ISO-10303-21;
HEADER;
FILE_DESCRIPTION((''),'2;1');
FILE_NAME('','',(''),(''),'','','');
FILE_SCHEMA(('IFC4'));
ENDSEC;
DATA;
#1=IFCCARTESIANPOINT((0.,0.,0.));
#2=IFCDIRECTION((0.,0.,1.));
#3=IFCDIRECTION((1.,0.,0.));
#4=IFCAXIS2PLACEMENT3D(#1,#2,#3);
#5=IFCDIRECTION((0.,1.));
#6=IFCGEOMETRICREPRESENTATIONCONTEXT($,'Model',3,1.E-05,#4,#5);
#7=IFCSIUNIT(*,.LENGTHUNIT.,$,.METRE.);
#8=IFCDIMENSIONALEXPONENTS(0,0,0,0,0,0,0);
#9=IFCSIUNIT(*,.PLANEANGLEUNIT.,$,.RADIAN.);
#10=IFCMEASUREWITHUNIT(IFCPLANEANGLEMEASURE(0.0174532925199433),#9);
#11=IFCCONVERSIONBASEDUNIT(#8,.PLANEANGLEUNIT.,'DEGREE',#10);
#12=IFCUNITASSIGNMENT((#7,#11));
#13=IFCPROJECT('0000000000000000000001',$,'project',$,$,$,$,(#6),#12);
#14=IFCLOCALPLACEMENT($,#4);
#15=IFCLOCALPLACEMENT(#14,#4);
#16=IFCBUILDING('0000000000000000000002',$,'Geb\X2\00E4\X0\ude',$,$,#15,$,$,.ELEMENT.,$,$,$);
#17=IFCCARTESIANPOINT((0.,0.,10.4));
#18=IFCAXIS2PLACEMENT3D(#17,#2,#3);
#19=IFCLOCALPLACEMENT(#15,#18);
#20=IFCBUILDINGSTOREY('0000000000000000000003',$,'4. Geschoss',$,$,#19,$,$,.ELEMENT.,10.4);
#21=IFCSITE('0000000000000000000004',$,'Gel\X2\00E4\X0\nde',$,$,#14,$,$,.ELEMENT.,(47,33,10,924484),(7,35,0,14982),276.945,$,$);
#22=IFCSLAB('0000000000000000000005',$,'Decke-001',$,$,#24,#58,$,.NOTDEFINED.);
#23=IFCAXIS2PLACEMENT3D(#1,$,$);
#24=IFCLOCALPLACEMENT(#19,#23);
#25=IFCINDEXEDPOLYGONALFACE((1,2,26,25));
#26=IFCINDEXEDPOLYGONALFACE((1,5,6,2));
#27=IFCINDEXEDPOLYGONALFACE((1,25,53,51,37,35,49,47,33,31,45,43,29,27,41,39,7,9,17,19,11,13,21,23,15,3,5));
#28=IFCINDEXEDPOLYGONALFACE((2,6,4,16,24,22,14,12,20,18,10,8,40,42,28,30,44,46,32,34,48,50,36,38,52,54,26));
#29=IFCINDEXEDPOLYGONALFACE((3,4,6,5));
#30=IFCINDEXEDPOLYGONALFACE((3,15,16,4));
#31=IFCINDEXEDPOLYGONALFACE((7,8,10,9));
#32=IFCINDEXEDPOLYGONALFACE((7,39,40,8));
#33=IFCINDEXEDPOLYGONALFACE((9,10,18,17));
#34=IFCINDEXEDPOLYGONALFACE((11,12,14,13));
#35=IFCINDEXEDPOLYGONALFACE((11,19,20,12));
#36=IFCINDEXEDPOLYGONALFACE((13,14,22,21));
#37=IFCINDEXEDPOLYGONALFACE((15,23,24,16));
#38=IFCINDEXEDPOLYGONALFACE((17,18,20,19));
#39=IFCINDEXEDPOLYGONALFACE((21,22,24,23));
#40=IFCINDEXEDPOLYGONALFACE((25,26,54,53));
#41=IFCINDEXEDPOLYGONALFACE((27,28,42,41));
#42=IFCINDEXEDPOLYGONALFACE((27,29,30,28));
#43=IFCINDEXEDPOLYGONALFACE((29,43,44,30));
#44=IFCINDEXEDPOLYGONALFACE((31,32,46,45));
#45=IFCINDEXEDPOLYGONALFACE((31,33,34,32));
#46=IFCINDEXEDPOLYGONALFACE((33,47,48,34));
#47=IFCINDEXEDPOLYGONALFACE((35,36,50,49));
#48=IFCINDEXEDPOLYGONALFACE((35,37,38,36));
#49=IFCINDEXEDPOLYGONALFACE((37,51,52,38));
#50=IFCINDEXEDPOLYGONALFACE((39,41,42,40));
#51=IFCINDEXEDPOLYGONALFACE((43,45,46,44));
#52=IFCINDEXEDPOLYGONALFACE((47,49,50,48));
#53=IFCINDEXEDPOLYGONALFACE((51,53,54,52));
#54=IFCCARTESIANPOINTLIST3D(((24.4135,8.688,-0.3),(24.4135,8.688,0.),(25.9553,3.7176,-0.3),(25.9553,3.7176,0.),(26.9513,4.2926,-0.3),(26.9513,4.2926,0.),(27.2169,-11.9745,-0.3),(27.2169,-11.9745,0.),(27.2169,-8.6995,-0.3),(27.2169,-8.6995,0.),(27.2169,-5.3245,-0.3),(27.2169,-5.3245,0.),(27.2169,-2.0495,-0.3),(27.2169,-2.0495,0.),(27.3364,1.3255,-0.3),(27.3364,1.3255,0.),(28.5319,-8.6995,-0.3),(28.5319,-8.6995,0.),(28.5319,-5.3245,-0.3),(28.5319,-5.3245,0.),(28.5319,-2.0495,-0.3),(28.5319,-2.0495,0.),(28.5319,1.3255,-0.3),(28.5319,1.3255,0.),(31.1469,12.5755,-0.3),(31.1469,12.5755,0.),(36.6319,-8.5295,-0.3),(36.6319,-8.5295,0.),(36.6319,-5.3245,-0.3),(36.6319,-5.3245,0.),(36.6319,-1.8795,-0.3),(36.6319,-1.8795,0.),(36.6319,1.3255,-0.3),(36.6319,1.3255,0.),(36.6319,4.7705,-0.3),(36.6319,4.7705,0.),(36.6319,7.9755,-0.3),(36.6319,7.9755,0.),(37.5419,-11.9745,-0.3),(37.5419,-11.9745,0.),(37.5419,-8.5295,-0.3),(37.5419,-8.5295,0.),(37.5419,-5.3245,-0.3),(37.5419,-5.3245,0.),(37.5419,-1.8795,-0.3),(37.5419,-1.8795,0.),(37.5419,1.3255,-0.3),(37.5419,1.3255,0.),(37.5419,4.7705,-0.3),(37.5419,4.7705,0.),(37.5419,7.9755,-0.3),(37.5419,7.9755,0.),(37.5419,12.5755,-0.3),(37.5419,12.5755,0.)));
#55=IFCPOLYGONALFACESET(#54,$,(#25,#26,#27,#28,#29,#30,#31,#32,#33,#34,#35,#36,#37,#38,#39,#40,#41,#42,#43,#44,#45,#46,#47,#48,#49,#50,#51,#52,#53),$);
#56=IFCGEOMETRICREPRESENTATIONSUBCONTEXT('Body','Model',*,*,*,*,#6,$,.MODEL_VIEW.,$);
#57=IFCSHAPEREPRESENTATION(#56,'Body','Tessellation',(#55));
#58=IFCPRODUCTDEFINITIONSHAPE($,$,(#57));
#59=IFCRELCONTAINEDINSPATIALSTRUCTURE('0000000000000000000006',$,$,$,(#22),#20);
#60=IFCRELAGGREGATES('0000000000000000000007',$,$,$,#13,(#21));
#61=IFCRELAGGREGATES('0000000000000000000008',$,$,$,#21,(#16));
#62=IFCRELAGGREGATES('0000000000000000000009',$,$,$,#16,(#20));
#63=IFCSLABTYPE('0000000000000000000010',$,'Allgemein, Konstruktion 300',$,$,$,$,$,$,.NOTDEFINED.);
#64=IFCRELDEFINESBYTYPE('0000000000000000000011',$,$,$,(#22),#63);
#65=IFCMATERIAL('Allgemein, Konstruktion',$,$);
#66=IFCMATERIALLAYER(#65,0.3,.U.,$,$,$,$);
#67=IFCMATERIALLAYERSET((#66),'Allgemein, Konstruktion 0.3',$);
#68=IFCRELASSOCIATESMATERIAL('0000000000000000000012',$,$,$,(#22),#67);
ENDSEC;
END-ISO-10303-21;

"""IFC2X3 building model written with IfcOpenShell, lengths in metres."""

from ifc_helpers import new_model, entity, si_unit, converted_unit, direction, frame, origin_with_axes, place, context, subcontext, project, spatial, polyline, outline, extrude, material, layer, layer_set, layer_usage, type_object, element, save


model = new_model("IFC2X3")

# Units and contexts
model_context = context("Model", 3, precision=1e-05, world=origin_with_axes(), true_north=direction((0.0, 1.0)))
body_context = subcontext(model_context, "Body", "Model", "MODEL_VIEW")
ifc_project = project(units=[si_unit("LENGTHUNIT", "METRE"), converted_unit("PLANEANGLEUNIT", "DEGREE", entity("IfcPlaneAngleMeasure", 0.0174532925199433), si_unit("PLANEANGLEUNIT", "RADIAN"), dimensions=[0, 0, 0, 0, 0, 0, 0])], contexts=[model_context])

# Site, building, storey
site_placement = place(None, origin_with_axes())
site = spatial("IfcSite", under=ifc_project, at=site_placement, Name="Gelände", CompositionType="ELEMENT", RefLatitude=(47, 33, 10, 924484), RefLongitude=(7, 35, 0, 14982), RefElevation=276.945)
building_placement = place(site_placement, origin_with_axes())
building = spatial("IfcBuilding", under=site, at=building_placement, Name="Gebäude", CompositionType="ELEMENT")
storey_placement = place(building_placement, frame((0.0, 0.0, 10.4), z_axis=(0.0, 0.0, 1.0), x_axis=(1.0, 0.0, 0.0)))
storey = spatial("IfcBuildingStorey", under=building, at=storey_placement, Name="4. Geschoss", CompositionType="ELEMENT", Elevation=10.4)

# Slab
ifc_material = material(Name="Allgemein, Konstruktion")
ifc_layer = layer(ifc_material, 0.3, ventilated="UNKNOWN")
ifc_layer_set = layer_set([ifc_layer], Name="Allgemein, Konstruktion 0.3")
ifc_layer_usage = layer_usage(ifc_layer_set, "AXIS3", "NEGATIVE", 0.3)
slab_type = type_object("IfcSlabType", Name="Allgemein, Konstruktion 300", PredefinedType="NOTDEFINED")
slab_placement = place(storey_placement, frame((24.4135, 8.688, 0.0), z_axis=(0.0, 0.0, 1.0), x_axis=(1.0, 0.0, 0.0)))
element("IfcSlab", 1, at=slab_placement, inside=storey, type_object=slab_type, material=ifc_layer_usage, Name="Decke-001", PredefinedType="NOTDEFINED", context=body_context, shape_type="SweptSolid", body=[
    extrude(outline(polyline([(0.0, 0.0), (2.5377, -4.3955), (1.5418, -4.9705), (2.9228, -7.3625), (4.1183, -7.3625), (4.1183, -10.7375), (2.8033, -10.7375), (2.8033, -14.0125), (4.1183, -14.0125), (4.1183, -17.3875), (2.8033, -17.3875), (2.8033, -20.6625), (13.1283, -20.6625), (13.1283, -17.2175), (12.2183, -17.2175), (12.2183, -14.0125), (13.1283, -14.0125), (13.1283, -10.5675), (12.2183, -10.5675), (12.2183, -7.3625), (13.1283, -7.3625), (13.1283, -3.9175), (12.2183, -3.9175), (12.2183, -0.7125), (13.1283, -0.7125), (13.1283, 3.8875), (6.7333, 3.8875), (0.0, 0.0)])), frame((0.0, 0.0, -0.3), z_axis=(0.0, 0.0, 1.0), x_axis=(1.0, 0.0, 0.0)), (0.0, 0.0, 1.0), 0.3),
])

save(model, "model.ifc")
